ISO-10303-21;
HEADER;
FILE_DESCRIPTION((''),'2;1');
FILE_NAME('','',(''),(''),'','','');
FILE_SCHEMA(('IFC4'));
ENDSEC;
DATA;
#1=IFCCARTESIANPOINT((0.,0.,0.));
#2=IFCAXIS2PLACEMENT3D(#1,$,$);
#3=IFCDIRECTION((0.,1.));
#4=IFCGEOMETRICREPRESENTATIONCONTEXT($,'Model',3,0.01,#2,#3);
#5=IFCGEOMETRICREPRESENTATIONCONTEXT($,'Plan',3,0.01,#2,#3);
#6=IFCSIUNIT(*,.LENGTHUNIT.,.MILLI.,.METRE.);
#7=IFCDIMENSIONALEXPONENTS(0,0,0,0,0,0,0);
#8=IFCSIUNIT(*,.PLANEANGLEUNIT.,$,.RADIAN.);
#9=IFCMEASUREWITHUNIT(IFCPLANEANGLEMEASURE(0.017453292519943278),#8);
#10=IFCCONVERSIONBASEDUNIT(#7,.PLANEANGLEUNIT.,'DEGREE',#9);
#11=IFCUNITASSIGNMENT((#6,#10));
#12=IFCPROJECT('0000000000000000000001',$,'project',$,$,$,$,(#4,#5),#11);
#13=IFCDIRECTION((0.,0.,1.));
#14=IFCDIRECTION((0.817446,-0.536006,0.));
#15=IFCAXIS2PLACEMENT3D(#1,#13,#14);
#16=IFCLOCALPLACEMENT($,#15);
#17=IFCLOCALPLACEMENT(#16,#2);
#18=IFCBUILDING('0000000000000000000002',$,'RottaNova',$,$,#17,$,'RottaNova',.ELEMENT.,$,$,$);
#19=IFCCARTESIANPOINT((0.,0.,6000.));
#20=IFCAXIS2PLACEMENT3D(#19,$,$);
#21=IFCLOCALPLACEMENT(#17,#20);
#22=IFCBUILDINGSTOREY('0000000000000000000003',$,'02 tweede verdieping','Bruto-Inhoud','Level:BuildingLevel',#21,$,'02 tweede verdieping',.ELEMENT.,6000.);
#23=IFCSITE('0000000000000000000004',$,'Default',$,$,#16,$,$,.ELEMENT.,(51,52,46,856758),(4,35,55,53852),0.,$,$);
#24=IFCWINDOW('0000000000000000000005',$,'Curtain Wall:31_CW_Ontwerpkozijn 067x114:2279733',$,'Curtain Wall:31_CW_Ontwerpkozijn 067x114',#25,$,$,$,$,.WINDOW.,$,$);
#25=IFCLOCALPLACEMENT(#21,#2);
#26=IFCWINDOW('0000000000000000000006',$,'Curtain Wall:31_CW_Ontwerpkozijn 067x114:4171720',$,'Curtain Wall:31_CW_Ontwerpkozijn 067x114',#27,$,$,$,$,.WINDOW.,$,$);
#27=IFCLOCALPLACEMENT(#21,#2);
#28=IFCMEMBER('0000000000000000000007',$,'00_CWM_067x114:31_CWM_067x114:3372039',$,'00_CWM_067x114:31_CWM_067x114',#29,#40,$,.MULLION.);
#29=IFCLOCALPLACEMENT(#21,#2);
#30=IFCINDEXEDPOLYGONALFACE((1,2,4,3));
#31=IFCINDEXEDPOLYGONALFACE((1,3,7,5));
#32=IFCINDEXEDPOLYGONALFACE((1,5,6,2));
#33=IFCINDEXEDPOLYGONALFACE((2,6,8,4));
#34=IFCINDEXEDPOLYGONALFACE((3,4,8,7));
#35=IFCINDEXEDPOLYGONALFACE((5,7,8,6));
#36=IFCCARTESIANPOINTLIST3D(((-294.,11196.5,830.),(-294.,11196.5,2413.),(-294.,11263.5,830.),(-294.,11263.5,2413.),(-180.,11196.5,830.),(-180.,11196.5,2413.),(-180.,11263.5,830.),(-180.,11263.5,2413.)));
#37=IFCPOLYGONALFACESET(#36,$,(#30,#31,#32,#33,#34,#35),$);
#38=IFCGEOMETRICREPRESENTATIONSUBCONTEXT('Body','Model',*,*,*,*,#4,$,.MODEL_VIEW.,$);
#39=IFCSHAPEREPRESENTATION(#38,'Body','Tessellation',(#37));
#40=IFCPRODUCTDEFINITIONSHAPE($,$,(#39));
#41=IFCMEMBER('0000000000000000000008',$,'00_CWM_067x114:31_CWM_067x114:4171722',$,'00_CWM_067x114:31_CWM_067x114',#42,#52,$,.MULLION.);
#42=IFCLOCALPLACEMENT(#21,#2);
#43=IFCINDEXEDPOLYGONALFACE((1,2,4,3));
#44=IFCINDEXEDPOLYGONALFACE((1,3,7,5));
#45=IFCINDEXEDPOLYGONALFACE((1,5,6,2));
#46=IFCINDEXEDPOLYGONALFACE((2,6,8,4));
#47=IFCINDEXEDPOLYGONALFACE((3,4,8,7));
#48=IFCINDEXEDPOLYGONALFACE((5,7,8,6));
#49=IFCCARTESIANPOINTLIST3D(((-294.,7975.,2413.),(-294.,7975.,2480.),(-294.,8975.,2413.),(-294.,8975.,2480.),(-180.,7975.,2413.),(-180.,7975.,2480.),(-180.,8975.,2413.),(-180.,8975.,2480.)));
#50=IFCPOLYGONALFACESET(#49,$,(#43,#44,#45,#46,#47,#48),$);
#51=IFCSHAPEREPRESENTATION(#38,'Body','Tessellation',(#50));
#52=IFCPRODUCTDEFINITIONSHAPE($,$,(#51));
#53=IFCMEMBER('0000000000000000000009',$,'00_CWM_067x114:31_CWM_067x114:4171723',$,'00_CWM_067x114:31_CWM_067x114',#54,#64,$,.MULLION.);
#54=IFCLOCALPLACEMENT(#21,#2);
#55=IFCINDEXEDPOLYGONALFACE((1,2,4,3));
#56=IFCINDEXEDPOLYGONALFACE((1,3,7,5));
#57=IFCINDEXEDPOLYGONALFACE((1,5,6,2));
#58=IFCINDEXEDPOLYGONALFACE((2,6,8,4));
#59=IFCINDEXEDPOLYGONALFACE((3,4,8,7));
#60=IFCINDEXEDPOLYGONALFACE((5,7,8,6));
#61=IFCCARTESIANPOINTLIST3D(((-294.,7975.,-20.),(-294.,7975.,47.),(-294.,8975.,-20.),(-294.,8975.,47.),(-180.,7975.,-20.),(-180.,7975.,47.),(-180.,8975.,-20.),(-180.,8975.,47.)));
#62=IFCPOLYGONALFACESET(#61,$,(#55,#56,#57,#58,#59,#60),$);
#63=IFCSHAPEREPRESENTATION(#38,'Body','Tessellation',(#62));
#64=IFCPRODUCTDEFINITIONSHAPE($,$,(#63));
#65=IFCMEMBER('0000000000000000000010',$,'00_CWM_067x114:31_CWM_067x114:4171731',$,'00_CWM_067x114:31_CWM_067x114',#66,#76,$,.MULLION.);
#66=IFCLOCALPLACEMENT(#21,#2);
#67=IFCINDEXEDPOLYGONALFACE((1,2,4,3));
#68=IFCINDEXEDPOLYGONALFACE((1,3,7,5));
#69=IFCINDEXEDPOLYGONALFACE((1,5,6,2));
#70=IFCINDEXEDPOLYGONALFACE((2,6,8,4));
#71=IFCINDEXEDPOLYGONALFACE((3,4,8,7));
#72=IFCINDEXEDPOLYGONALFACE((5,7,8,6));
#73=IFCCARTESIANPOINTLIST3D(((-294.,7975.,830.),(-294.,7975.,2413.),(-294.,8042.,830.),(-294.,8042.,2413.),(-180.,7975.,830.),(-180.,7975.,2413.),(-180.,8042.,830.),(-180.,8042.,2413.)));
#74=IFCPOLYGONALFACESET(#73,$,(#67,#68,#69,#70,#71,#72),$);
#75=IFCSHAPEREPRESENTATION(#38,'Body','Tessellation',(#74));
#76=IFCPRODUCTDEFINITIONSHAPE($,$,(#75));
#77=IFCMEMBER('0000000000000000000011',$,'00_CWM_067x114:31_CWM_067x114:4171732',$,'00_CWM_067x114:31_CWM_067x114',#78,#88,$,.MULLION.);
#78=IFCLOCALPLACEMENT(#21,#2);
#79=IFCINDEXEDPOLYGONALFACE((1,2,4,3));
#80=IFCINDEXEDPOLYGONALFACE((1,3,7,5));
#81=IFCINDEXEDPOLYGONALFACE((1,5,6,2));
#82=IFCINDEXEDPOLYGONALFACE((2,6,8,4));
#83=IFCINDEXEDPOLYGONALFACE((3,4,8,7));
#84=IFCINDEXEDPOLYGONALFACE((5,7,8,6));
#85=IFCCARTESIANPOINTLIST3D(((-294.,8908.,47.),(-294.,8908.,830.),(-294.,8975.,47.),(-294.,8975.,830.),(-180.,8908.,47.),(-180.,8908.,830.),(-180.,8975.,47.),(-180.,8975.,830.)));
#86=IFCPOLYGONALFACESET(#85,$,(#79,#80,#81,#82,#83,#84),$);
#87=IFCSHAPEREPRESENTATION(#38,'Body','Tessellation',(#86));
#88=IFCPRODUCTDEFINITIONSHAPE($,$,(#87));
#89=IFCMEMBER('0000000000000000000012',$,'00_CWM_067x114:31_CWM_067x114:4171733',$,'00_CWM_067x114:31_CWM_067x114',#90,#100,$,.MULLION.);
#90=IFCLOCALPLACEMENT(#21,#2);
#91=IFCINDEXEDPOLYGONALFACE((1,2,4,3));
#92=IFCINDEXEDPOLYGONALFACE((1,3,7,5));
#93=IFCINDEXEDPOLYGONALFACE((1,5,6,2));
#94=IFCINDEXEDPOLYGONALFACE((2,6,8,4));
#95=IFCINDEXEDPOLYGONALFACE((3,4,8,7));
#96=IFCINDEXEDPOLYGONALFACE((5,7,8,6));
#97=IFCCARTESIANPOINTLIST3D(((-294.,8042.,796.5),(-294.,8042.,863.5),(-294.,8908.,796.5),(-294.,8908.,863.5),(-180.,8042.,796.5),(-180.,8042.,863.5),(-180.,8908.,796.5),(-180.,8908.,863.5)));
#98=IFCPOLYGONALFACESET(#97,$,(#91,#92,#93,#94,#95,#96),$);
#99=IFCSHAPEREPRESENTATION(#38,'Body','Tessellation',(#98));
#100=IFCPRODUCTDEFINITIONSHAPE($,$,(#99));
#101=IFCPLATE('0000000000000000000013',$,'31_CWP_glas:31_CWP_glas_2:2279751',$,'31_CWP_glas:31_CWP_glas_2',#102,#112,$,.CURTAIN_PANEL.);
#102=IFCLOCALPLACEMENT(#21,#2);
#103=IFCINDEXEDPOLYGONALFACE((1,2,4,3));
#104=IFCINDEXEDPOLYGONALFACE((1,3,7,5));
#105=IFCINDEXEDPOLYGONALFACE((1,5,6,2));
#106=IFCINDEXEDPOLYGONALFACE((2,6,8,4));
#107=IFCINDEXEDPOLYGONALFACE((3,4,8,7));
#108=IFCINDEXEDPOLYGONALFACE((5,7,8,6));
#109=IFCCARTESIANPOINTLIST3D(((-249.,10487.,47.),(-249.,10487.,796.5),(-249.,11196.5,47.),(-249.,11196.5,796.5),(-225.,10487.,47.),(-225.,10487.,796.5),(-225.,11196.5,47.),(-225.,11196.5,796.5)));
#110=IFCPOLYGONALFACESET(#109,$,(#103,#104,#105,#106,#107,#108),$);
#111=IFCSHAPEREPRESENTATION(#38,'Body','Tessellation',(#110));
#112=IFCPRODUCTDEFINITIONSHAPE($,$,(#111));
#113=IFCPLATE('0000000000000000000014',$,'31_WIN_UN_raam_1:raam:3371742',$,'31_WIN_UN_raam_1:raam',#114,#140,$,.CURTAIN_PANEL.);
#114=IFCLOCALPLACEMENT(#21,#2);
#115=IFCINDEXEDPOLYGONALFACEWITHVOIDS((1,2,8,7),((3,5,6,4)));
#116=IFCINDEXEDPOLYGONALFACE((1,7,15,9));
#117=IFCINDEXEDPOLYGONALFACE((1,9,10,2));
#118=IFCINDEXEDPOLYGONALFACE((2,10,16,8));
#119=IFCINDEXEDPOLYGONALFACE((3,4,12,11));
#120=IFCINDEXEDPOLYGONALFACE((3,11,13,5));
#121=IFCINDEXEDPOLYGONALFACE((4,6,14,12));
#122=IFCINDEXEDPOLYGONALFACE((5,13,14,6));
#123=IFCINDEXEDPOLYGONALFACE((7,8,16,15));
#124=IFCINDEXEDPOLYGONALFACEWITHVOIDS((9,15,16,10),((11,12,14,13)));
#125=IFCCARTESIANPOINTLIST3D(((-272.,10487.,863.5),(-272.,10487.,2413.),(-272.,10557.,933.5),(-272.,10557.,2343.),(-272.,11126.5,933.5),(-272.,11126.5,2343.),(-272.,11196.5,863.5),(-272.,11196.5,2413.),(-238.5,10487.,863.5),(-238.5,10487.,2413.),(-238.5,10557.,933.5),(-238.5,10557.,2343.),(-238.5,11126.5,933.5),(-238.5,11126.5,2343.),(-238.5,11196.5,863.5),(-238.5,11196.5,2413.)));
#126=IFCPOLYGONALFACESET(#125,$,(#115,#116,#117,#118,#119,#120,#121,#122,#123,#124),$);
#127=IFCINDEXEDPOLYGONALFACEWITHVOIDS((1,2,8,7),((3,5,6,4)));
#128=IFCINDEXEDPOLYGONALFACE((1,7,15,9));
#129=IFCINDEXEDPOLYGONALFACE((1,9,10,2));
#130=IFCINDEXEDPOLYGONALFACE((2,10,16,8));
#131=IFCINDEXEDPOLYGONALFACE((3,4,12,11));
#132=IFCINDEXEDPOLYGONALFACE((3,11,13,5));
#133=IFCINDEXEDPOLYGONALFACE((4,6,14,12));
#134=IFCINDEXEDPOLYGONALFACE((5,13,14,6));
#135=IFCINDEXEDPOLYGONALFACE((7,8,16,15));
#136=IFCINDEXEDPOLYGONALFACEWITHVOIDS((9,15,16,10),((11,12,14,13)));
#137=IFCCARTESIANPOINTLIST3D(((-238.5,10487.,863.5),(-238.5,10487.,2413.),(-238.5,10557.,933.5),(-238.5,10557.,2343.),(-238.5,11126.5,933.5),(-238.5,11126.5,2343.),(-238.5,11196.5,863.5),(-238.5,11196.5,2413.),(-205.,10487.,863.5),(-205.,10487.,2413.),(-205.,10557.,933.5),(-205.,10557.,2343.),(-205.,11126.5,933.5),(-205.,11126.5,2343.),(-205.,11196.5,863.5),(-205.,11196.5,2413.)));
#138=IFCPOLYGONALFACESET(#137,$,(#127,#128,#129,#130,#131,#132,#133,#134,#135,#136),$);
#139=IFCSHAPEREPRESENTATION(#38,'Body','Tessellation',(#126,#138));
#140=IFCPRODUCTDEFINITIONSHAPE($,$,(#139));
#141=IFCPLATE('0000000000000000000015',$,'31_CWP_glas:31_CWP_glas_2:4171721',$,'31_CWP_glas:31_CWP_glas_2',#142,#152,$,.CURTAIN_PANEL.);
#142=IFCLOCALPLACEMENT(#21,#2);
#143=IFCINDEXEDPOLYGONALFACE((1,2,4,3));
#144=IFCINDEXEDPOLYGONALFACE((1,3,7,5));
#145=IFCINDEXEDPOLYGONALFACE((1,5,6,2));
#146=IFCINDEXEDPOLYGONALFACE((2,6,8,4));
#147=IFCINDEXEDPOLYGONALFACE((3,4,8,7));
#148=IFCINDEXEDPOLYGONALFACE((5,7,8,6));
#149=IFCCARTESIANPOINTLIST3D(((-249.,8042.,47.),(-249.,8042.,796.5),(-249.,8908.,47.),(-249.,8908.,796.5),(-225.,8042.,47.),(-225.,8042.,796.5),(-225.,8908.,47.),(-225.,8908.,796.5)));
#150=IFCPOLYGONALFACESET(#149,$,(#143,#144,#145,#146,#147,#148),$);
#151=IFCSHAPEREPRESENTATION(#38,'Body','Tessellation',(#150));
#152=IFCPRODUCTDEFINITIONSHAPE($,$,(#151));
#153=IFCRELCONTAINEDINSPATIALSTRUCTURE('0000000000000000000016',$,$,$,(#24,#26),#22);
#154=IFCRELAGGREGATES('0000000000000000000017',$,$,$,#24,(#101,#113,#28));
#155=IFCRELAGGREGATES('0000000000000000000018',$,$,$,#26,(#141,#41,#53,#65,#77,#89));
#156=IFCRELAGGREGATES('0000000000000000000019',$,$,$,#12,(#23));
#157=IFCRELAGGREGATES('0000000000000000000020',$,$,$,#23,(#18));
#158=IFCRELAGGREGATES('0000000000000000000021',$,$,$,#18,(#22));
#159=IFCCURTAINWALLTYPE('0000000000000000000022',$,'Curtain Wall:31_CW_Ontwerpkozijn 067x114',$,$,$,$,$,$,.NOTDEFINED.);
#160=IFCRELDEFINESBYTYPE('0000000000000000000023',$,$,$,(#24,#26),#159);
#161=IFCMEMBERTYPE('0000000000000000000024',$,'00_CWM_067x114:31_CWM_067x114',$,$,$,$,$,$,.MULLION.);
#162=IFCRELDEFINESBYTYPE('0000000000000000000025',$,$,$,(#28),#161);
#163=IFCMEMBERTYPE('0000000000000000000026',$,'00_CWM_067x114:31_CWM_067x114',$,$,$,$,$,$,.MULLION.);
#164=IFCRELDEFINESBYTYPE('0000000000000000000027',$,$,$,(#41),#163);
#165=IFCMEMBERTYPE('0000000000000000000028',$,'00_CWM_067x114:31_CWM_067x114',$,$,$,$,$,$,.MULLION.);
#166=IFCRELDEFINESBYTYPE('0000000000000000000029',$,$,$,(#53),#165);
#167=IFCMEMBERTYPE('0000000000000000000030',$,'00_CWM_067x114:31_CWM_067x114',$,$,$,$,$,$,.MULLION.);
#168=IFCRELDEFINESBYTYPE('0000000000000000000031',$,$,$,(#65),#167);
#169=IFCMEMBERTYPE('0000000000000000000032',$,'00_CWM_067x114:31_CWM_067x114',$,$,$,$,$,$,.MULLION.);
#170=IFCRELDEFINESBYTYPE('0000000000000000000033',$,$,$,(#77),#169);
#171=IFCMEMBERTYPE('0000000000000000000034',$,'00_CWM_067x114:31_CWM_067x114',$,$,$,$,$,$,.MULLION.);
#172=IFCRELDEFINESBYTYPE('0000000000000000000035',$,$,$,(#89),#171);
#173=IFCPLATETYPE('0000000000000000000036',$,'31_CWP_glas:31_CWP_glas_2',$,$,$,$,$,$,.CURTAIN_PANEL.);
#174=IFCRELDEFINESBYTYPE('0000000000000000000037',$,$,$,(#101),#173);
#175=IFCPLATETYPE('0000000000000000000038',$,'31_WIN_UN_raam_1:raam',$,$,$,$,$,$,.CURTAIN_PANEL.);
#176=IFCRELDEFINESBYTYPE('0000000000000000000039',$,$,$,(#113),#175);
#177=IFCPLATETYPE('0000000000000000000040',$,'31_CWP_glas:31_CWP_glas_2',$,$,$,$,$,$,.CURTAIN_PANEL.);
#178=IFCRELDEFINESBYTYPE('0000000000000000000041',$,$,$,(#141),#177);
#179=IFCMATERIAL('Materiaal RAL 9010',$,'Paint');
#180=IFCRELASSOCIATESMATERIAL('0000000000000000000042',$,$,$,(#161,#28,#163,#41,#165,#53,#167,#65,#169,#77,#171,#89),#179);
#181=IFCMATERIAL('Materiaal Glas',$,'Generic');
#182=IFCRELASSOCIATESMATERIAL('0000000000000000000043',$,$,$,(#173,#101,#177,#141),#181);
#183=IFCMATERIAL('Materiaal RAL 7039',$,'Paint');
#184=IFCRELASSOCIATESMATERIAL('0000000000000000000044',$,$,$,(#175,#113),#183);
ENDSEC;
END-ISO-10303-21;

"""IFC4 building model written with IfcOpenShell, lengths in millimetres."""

from ifc_helpers import new_model, entity, si_unit, converted_unit, direction, frame, origin, place, context, subcontext, project, spatial, indexed_curve, outline, extrude, source, transform, mapped, material, type_object, type_shapes, element, aggregate, save


model = new_model("IFC4")

# Units and contexts
model_context = context("Model", 3, precision=0.01, world=origin(), true_north=direction((0.0, 1.0)))
plan_context = context("Plan", 3, precision=0.01, world=origin(), true_north=direction((0.0, 1.0)))
body_context = subcontext(model_context, "Body", "Model", "MODEL_VIEW")
ifc_project = project(units=[si_unit("LENGTHUNIT", "METRE", prefix="MILLI"), converted_unit("PLANEANGLEUNIT", "DEGREE", entity("IfcPlaneAngleMeasure", 0.017453292519943278), si_unit("PLANEANGLEUNIT", "RADIAN"), dimensions=[0, 0, 0, 0, 0, 0, 0])], contexts=[model_context, plan_context])

# Site, building, storey
site_placement = place(None, frame((0.0, 0.0, 0.0), z_axis=(0.0, 0.0, 1.0), x_axis=(0.817446, -0.536006, 0.0)))
site = spatial("IfcSite", under=ifc_project, at=site_placement, Name="Default", CompositionType="ELEMENT", RefLatitude=(51, 52, 46, 856758), RefLongitude=(4, 35, 55, 53852), RefElevation=0.0)
building_placement = place(site_placement, origin())
building = spatial("IfcBuilding", under=site, at=building_placement, Name="RottaNova", LongName="RottaNova", CompositionType="ELEMENT")
storey_placement = place(building_placement, frame((0.0, 0.0, 6000.0)))
storey = spatial("IfcBuildingStorey", under=building, at=storey_placement, Name="02 tweede verdieping", Description="Bruto-Inhoud", ObjectType="Level:BuildingLevel", LongName="02 tweede verdieping", CompositionType="ELEMENT", Elevation=6000.0)

# Windows
curtain_wall_type = type_object("IfcCurtainWallType", Name="Curtain Wall:31_CW_Ontwerpkozijn 067x114", PredefinedType="NOTDEFINED")
window_1_placement = place(storey_placement, frame((0.0, 0.0, -6000.0)))
window_1 = element("IfcWindow", 1, at=window_1_placement, inside=storey, type_object=curtain_wall_type, Name="Curtain Wall:31_CW_Ontwerpkozijn 067x114:2279733", ObjectType="Curtain Wall:31_CW_Ontwerpkozijn 067x114", PredefinedType="WINDOW")
ifc_material_1 = material(Name="Materiaal RAL 9010", Category="Paint")
window_2_placement = place(storey_placement, frame((0.0, 0.0, -6000.0)))
window_2 = element("IfcWindow", 2, at=window_2_placement, inside=storey, type_object=curtain_wall_type, Name="Curtain Wall:31_CW_Ontwerpkozijn 067x114:4171720", ObjectType="Curtain Wall:31_CW_Ontwerpkozijn 067x114", PredefinedType="WINDOW")

# Members
member_type_1 = type_object("IfcMemberType", Name="00_CWM_067x114:31_CWM_067x114", PredefinedType="MULLION", material=ifc_material_1)
shared_shape_1 = source(origin(), body_context, "Body", "SweptSolid", [
    extrude(outline(indexed_curve([(-33.5, -57.0), (33.5, -57.0), (33.5, 57.0), (-33.5, 57.0), (-33.5, -57.0)], self_intersect=False)), frame((0.0, 57.0, -1583.0), z_axis=(0.0, 0.0, 1.0), x_axis=(-1.0, 0.0, 0.0)), (0.0, 0.0, 1.0), 1583.0),
])
type_shapes(member_type_1, [shared_shape_1])
member_1_placement = place(window_1_placement, frame((-180.0, 11230.0, 6830.0), z_axis=(0.0, 0.0, -1.0), x_axis=(0.0, -1.0, 0.0)))
member_1 = element("IfcMember", 3, at=member_1_placement, type_object=member_type_1, material=ifc_material_1, Name="00_CWM_067x114:31_CWM_067x114:3372039", ObjectType="00_CWM_067x114:31_CWM_067x114", PredefinedType="MULLION", context=body_context, shape_type="MappedRepresentation", body=[
    mapped(shared_shape_1, transform((0.0, 0.0, 0.0), scale=1.0)),
])
member_type_2 = type_object("IfcMemberType", Name="00_CWM_067x114:31_CWM_067x114", PredefinedType="MULLION", material=ifc_material_1)
shared_shape_2 = source(origin(), body_context, "Body", "SweptSolid", [
    extrude(outline(indexed_curve([(-33.5, -57.0), (33.5, -57.0), (33.5, 57.0), (-33.5, 57.0), (-33.5, -57.0)], self_intersect=False)), frame((-33.5, 57.0, -1000.0), z_axis=(0.0, 0.0, 1.0), x_axis=(-1.0, 0.0, 0.0)), (0.0, 0.0, 1.0), 1000.0),
])
type_shapes(member_type_2, [shared_shape_2])
member_2_placement = place(window_2_placement, frame((-180.0, 7975.0, 8480.0), z_axis=(0.0, -1.0, 0.0), x_axis=(0.0, 0.0, 1.0)))
member_2 = element("IfcMember", 4, at=member_2_placement, type_object=member_type_2, material=ifc_material_1, Name="00_CWM_067x114:31_CWM_067x114:4171722", ObjectType="00_CWM_067x114:31_CWM_067x114", PredefinedType="MULLION", context=body_context, shape_type="MappedRepresentation", body=[
    mapped(shared_shape_2, transform((0.0, 0.0, 0.0), scale=1.0)),
])
member_type_3 = type_object("IfcMemberType", Name="00_CWM_067x114:31_CWM_067x114", PredefinedType="MULLION", material=ifc_material_1)
shared_shape_3 = source(origin(), body_context, "Body", "SweptSolid", [
    extrude(outline(indexed_curve([(-33.5, -57.0), (33.5, -57.0), (33.5, 57.0), (-33.5, 57.0), (-33.5, -57.0)], self_intersect=False)), frame((-33.5, 57.0, -1000.0), z_axis=(0.0, 0.0, 1.0), x_axis=(-1.0, 0.0, 0.0)), (0.0, 0.0, 1.0), 1000.0),
])
type_shapes(member_type_3, [shared_shape_3])
member_3_placement = place(window_2_placement, frame((-180.0, 8975.0, 5980.0), z_axis=(0.0, 1.0, 0.0), x_axis=(0.0, 0.0, -1.0)))
member_3 = element("IfcMember", 5, at=member_3_placement, type_object=member_type_3, material=ifc_material_1, Name="00_CWM_067x114:31_CWM_067x114:4171723", ObjectType="00_CWM_067x114:31_CWM_067x114", PredefinedType="MULLION", context=body_context, shape_type="MappedRepresentation", body=[
    mapped(shared_shape_3, transform((0.0, 0.0, 0.0), scale=1.0)),
])
member_type_4 = type_object("IfcMemberType", Name="00_CWM_067x114:31_CWM_067x114", PredefinedType="MULLION", material=ifc_material_1)
shared_shape_4 = source(origin(), body_context, "Body", "SweptSolid", [
    extrude(outline(indexed_curve([(-33.5, -57.0), (33.5, -57.0), (33.5, 57.0), (-33.5, 57.0), (-33.5, -57.0)], self_intersect=False)), frame((-33.5, 57.0, -1583.0), z_axis=(0.0, 0.0, 1.0), x_axis=(-1.0, 0.0, 0.0)), (0.0, 0.0, 1.0), 1583.0),
])
type_shapes(member_type_4, [shared_shape_4])
member_4_placement = place(window_2_placement, frame((-180.0, 7975.0, 6830.0), z_axis=(0.0, 0.0, -1.0), x_axis=(0.0, -1.0, 0.0)))
member_4 = element("IfcMember", 6, at=member_4_placement, type_object=member_type_4, material=ifc_material_1, Name="00_CWM_067x114:31_CWM_067x114:4171731", ObjectType="00_CWM_067x114:31_CWM_067x114", PredefinedType="MULLION", context=body_context, shape_type="MappedRepresentation", body=[
    mapped(shared_shape_4, transform((0.0, 0.0, 0.0), scale=1.0)),
])
member_type_5 = type_object("IfcMemberType", Name="00_CWM_067x114:31_CWM_067x114", PredefinedType="MULLION", material=ifc_material_1)
shared_shape_5 = source(origin(), body_context, "Body", "SweptSolid", [
    extrude(outline(indexed_curve([(-33.5, -57.0), (33.5, -57.0), (33.5, 57.0), (-33.5, 57.0), (-33.5, -57.0)], self_intersect=False)), frame((-33.5, 57.0, -783.0), z_axis=(0.0, 0.0, 1.0), x_axis=(-1.0, 0.0, 0.0)), (0.0, 0.0, 1.0), 783.0),
])
type_shapes(member_type_5, [shared_shape_5])
member_5_placement = place(window_2_placement, frame((-180.0, 8975.0, 6830.0), z_axis=(0.0, 0.0, 1.0), x_axis=(0.0, 1.0, 0.0)))
member_5 = element("IfcMember", 7, at=member_5_placement, type_object=member_type_5, material=ifc_material_1, Name="00_CWM_067x114:31_CWM_067x114:4171732", ObjectType="00_CWM_067x114:31_CWM_067x114", PredefinedType="MULLION", context=body_context, shape_type="MappedRepresentation", body=[
    mapped(shared_shape_5, transform((0.0, 0.0, 0.0), scale=1.0)),
])
member_type_6 = type_object("IfcMemberType", Name="00_CWM_067x114:31_CWM_067x114", PredefinedType="MULLION", material=ifc_material_1)
shared_shape_6 = source(origin(), body_context, "Body", "SweptSolid", [
    extrude(outline(indexed_curve([(-33.5, -57.0), (33.5, -57.0), (33.5, 57.0), (-33.5, 57.0), (-33.5, -57.0)], self_intersect=False)), frame((0.0, 57.0, -866.0), z_axis=(0.0, 0.0, 1.0), x_axis=(-1.0, 0.0, 0.0)), (0.0, 0.0, 1.0), 866.0),
])
type_shapes(member_type_6, [shared_shape_6])
member_6_placement = place(window_2_placement, frame((-180.0, 8042.0, 6830.0), z_axis=(0.0, -1.0, 0.0), x_axis=(0.0, 0.0, 1.0)))
member_6 = element("IfcMember", 8, at=member_6_placement, type_object=member_type_6, material=ifc_material_1, Name="00_CWM_067x114:31_CWM_067x114:4171733", ObjectType="00_CWM_067x114:31_CWM_067x114", PredefinedType="MULLION", context=body_context, shape_type="MappedRepresentation", body=[
    mapped(shared_shape_6, transform((0.0, 0.0, 0.0), scale=1.0)),
])

# Plates
ifc_material_2 = material(Name="Materiaal Glas", Category="Generic")
plate_type_1 = type_object("IfcPlateType", Name="31_CWP_glas:31_CWP_glas_2", PredefinedType="CURTAIN_PANEL", material=ifc_material_2)
shared_shape_7 = source(origin(), body_context, "Body", "SweptSolid", [
    extrude(outline(indexed_curve([(-12.0, -354.8), (12.0, -354.8), (12.0, 354.8), (-12.0, 354.8), (-12.0, -354.8)], self_intersect=False)), frame((0.0, -57.0, 0.0), z_axis=(0.0, 0.0, 1.0), x_axis=(0.0, 1.0, 0.0)), (0.0, 0.0, 1.0), 749.5),
])
type_shapes(plate_type_1, [shared_shape_7])
plate_1_placement = place(window_1_placement, frame((-180.0, 10841.7, 6047.0), z_axis=(0.0, 0.0, 1.0), x_axis=(0.0, -1.0, 0.0)))
plate_1 = element("IfcPlate", 9, at=plate_1_placement, type_object=plate_type_1, material=ifc_material_2, Name="31_CWP_glas:31_CWP_glas_2:2279751", ObjectType="31_CWP_glas:31_CWP_glas_2", PredefinedType="CURTAIN_PANEL", context=body_context, shape_type="MappedRepresentation", body=[
    mapped(shared_shape_7, transform((0.0, 0.0, 0.0), scale=1.0)),
])
ifc_material_3 = material(Name="Materiaal RAL 7039", Category="Paint")
plate_type_2 = type_object("IfcPlateType", Name="31_WIN_UN_raam_1:raam", PredefinedType="CURTAIN_PANEL", material=ifc_material_3)
shared_shape_8 = source(origin(), body_context, "Body", "SweptSolid", [
    extrude(outline(indexed_curve([(-354.7, -774.7), (354.7, -774.7), (354.7, 774.7), (-354.7, 774.7), (-354.7, -774.7)], self_intersect=False), holes=[indexed_curve([(-284.7, 704.7), (284.7, 704.7), (284.7, -704.8), (-284.7, -704.8), (-284.7, 704.7)], self_intersect=False)]), frame((0.0, -92.0, 774.8), z_axis=(0.0, 1.0, 0.0), x_axis=(1.0, 0.0, 0.0)), (0.0, 0.0, 1.0), 33.5),
    extrude(outline(indexed_curve([(-354.7, -774.7), (354.7, -774.7), (354.7, 774.7), (-354.7, 774.7), (-354.7, -774.7)], self_intersect=False), holes=[indexed_curve([(-284.7, 704.7), (284.7, 704.7), (284.7, -704.8), (-284.7, -704.8), (-284.7, 704.7)], self_intersect=False)]), frame((0.0, -58.5, 774.8), z_axis=(0.0, 1.0, 0.0), x_axis=(1.0, 0.0, 0.0)), (0.0, 0.0, 1.0), 33.5),
])
type_shapes(plate_type_2, [shared_shape_8])
plate_2_placement = place(window_1_placement, frame((-180.0, 10841.7, 6863.5), z_axis=(0.0, 0.0, 1.0), x_axis=(0.0, -1.0, 0.0)))
plate_2 = element("IfcPlate", 10, at=plate_2_placement, type_object=plate_type_2, material=ifc_material_3, Name="31_WIN_UN_raam_1:raam:3371742", ObjectType="31_WIN_UN_raam_1:raam", PredefinedType="CURTAIN_PANEL", context=body_context, shape_type="MappedRepresentation", body=[
    mapped(shared_shape_8, transform((0.0, 0.0, 0.0), scale=1.0)),
])
aggregate(window_1, [plate_1, plate_2, member_1])
plate_type_3 = type_object("IfcPlateType", Name="31_CWP_glas:31_CWP_glas_2", PredefinedType="CURTAIN_PANEL", material=ifc_material_2)
shared_shape_9 = source(origin(), body_context, "Body", "SweptSolid", [
    extrude(outline(indexed_curve([(-12.0, -433.0), (12.0, -433.0), (12.0, 433.0), (-12.0, 433.0), (-12.0, -433.0)], self_intersect=False)), frame((0.0, -57.0, 0.0), z_axis=(0.0, 0.0, 1.0), x_axis=(0.0, 1.0, 0.0)), (0.0, 0.0, 1.0), 749.5),
])
type_shapes(plate_type_3, [shared_shape_9])
plate_3_placement = place(window_2_placement, frame((-180.0, 8475.0, 6047.0), z_axis=(0.0, 0.0, 1.0), x_axis=(0.0, -1.0, 0.0)))
plate_3 = element("IfcPlate", 11, at=plate_3_placement, type_object=plate_type_3, material=ifc_material_2, Name="31_CWP_glas:31_CWP_glas_2:4171721", ObjectType="31_CWP_glas:31_CWP_glas_2", PredefinedType="CURTAIN_PANEL", context=body_context, shape_type="MappedRepresentation", body=[
    mapped(shared_shape_9, transform((0.0, 0.0, 0.0), scale=1.0)),
])
aggregate(window_2, [plate_3, member_2, member_3, member_4, member_5, member_6])

save(model, "model.ifc")
